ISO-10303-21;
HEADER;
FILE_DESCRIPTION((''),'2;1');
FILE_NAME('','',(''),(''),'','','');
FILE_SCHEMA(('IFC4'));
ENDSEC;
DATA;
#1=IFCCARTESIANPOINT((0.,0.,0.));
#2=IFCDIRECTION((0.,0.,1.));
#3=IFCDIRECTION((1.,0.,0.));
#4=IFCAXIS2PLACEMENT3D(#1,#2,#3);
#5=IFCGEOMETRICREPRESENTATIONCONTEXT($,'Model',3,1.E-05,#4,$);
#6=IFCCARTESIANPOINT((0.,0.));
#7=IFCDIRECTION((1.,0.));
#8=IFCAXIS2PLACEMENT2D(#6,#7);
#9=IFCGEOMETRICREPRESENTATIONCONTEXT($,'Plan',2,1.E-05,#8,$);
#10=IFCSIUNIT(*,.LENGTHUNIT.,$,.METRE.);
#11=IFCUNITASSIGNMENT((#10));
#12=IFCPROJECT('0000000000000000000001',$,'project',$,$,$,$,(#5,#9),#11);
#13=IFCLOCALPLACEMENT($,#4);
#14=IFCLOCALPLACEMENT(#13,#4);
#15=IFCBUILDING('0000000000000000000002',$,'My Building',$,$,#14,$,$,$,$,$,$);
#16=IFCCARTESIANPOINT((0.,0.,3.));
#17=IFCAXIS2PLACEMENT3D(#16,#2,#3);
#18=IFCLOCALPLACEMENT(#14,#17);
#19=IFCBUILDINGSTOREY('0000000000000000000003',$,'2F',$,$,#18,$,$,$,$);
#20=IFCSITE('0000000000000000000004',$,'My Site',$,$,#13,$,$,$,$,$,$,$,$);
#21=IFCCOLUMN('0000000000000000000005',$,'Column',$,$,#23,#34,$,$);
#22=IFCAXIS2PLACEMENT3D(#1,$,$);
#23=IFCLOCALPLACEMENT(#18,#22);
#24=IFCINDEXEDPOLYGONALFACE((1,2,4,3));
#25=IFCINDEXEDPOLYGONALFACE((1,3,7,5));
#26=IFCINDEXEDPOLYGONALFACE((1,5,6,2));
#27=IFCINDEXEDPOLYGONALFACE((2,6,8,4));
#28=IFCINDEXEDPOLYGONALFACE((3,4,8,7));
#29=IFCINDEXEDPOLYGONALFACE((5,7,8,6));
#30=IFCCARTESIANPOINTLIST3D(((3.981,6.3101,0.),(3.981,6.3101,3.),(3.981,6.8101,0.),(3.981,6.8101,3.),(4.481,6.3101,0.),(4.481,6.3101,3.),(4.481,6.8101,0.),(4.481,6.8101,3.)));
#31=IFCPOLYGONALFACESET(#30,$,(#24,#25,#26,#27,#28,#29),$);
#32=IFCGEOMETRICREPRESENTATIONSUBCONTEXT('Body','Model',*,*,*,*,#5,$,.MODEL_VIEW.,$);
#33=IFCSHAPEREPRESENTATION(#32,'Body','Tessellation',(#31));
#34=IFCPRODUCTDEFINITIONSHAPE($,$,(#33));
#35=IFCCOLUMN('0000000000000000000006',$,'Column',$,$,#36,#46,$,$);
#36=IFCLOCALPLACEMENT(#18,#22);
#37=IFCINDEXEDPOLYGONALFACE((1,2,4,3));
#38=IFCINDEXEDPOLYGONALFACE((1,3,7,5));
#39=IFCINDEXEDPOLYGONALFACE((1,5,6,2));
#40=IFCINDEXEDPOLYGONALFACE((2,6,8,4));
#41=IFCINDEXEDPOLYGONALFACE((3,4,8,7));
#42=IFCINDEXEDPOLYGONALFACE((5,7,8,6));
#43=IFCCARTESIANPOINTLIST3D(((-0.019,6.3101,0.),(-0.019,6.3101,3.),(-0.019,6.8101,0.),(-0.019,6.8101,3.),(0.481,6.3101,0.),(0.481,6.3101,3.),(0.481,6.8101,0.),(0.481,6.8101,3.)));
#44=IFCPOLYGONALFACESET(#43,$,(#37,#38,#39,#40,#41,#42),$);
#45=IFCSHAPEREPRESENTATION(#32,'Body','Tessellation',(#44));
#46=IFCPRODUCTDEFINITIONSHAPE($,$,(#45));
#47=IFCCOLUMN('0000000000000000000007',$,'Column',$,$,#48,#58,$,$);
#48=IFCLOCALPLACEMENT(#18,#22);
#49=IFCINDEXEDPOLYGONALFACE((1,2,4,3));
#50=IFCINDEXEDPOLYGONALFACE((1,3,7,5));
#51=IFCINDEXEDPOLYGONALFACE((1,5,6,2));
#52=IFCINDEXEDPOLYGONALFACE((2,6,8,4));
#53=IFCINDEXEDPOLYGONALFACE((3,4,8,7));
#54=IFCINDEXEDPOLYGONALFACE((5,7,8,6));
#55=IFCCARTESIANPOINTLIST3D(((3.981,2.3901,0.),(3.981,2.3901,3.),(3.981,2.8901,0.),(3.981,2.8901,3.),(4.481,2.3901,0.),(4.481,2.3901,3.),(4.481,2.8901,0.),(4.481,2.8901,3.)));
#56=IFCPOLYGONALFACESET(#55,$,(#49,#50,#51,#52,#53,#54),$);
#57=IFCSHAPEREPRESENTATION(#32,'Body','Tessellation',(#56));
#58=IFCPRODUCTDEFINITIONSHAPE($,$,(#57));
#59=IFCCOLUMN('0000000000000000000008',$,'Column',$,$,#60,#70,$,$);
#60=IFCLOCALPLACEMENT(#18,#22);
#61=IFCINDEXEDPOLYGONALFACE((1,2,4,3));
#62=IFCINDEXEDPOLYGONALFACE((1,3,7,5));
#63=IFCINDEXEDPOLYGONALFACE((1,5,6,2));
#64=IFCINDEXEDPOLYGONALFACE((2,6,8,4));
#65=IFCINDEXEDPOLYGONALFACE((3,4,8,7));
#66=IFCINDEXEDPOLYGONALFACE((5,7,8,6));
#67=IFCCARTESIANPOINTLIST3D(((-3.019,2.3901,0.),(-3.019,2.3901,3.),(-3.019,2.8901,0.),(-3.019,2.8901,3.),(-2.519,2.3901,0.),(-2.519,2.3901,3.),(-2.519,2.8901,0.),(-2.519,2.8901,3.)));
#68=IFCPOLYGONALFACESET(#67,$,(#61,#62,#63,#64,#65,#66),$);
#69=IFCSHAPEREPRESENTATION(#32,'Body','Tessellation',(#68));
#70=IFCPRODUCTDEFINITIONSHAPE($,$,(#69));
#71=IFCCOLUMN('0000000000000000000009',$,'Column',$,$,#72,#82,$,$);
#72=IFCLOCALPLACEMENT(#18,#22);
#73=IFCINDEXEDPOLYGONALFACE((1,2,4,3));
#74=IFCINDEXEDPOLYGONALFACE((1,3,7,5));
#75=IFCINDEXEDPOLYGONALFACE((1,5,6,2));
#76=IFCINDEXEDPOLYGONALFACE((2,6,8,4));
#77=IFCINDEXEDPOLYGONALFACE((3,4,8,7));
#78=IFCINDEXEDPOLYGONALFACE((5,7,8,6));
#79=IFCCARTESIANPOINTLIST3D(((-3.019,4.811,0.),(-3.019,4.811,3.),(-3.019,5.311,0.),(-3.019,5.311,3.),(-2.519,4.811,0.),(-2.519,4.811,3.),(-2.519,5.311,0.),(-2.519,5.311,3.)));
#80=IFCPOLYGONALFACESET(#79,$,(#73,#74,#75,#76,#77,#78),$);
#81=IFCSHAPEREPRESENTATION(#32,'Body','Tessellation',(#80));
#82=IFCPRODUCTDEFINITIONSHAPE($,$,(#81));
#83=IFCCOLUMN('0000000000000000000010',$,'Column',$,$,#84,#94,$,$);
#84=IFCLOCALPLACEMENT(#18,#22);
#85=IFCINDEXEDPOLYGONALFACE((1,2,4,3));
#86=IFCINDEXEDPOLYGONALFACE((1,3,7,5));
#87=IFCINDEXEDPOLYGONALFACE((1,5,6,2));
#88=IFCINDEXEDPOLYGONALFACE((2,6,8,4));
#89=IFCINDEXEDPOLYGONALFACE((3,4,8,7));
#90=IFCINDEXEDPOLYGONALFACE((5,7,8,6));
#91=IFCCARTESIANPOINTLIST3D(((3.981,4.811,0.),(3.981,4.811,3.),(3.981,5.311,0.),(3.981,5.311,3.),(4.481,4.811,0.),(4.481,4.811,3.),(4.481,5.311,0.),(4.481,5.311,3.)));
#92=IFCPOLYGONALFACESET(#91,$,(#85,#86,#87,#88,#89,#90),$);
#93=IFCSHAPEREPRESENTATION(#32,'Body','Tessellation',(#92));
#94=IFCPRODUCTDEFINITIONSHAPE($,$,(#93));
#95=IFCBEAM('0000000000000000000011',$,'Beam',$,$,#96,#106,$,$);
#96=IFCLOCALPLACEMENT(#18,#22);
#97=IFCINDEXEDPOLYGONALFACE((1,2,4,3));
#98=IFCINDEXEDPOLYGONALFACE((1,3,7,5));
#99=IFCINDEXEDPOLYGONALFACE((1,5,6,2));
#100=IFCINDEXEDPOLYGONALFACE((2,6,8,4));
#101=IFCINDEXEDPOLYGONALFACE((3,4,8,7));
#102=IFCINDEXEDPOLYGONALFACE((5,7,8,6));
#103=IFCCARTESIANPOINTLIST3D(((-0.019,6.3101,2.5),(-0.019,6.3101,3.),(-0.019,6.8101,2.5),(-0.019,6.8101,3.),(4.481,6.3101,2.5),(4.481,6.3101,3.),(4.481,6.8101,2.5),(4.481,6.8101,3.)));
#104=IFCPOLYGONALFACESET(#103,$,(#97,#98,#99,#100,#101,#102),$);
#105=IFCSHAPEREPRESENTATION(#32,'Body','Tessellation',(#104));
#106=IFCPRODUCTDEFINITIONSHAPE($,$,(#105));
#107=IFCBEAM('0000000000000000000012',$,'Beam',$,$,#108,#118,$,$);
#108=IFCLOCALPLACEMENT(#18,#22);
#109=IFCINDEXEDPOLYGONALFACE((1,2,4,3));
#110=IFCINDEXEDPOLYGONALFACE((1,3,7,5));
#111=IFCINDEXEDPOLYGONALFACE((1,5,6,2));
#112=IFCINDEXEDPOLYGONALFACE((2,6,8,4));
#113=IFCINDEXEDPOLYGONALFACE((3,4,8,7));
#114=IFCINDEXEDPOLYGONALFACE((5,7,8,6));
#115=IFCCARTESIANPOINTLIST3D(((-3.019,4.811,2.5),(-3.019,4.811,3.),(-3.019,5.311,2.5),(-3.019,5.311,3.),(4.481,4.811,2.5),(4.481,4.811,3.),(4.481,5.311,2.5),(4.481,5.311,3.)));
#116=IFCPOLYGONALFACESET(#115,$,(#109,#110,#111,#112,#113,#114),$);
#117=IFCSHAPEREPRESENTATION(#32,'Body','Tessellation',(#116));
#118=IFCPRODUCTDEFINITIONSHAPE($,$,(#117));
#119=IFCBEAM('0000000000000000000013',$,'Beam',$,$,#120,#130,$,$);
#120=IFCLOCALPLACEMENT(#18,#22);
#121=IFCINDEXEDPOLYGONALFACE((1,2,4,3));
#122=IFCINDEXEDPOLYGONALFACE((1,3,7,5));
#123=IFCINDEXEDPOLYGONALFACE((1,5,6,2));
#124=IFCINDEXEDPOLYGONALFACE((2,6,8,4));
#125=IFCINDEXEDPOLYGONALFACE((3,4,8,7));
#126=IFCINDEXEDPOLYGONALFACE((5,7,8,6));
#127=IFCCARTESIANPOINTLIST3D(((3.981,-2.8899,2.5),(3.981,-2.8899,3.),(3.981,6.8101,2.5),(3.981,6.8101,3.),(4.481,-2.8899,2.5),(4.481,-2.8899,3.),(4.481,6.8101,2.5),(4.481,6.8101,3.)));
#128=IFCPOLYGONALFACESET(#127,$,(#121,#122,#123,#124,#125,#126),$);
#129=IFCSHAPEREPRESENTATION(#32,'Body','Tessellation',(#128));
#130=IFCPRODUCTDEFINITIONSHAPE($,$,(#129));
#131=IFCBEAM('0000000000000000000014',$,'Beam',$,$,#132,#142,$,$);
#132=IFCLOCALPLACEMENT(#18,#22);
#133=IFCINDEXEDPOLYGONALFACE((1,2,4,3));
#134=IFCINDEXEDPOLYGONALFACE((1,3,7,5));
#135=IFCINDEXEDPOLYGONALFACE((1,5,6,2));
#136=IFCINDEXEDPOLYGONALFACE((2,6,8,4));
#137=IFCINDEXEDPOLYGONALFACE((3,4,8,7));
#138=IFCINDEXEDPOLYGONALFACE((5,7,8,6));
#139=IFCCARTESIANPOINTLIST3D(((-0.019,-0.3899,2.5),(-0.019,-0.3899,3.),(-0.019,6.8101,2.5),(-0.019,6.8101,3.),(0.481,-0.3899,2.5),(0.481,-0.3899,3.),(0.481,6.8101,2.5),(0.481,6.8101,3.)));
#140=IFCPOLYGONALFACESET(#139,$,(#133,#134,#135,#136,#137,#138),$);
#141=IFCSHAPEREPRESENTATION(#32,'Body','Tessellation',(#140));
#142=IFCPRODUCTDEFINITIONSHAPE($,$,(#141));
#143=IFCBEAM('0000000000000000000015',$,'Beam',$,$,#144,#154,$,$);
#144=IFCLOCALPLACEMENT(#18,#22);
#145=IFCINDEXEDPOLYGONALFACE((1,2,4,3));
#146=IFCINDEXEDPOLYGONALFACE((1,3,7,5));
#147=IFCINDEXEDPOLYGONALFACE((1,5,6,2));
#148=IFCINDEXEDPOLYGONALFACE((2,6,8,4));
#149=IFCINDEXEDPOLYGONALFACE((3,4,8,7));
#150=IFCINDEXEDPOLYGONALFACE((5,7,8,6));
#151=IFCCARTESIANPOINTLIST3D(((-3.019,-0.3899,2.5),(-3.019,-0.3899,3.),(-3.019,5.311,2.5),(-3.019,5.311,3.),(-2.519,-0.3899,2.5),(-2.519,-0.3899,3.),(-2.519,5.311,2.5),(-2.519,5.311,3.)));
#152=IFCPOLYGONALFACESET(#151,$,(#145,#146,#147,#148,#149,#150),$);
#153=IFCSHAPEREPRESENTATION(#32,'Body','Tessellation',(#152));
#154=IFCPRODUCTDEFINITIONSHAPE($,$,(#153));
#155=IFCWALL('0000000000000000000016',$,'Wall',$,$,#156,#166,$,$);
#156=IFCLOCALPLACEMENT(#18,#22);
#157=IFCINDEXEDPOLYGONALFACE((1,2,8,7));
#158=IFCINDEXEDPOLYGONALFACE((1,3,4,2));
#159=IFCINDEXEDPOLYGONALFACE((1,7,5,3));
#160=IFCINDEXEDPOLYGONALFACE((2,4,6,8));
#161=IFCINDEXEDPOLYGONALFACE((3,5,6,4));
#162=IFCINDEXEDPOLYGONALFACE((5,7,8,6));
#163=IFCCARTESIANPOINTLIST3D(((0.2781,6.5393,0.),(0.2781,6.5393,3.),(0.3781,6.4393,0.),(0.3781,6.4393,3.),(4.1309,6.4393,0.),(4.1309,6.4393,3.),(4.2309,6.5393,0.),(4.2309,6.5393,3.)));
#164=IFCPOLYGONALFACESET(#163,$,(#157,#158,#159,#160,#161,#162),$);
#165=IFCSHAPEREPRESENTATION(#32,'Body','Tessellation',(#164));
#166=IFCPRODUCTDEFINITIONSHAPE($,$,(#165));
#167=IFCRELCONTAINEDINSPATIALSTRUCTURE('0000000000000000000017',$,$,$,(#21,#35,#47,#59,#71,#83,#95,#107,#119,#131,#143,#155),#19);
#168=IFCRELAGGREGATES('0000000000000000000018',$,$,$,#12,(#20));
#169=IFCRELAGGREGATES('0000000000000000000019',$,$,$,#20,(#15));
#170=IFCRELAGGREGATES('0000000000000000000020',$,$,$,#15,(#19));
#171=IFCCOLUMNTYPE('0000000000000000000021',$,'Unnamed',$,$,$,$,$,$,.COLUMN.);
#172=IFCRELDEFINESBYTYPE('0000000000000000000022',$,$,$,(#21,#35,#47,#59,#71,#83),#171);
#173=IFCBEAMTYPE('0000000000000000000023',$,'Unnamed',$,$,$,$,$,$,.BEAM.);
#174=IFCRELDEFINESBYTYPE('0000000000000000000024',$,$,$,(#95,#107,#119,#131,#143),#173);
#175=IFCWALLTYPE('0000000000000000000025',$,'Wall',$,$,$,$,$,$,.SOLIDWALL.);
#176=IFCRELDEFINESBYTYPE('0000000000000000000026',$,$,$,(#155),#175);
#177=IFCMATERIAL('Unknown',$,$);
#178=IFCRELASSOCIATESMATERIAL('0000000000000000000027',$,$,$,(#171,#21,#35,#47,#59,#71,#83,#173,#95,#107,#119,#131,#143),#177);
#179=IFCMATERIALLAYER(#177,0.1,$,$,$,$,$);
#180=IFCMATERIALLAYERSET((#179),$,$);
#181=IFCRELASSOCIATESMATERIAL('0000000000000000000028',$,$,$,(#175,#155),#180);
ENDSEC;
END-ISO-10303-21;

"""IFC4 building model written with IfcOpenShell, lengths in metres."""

from ifc_helpers import new_model, si_unit, frame, origin_with_axes, origin_2d_with_axis, place, context, subcontext, project, spatial, line, indexed_curve, rectangle, outline, extrude, material, layer, layer_set, layer_usage, material_profile, profile_set, profile_usage, type_object, element, save


model = new_model("IFC4")

# Units and contexts
model_context = context("Model", 3, precision=1e-05, world=origin_with_axes())
plan_context = context("Plan", 2, precision=1e-05, world=origin_2d_with_axis())
body_context_1 = subcontext(model_context, "Body", "Model", "MODEL_VIEW")
ifc_project = project(units=[si_unit("LENGTHUNIT", "METRE")], contexts=[model_context, plan_context])

# Site, building, storey
site_placement = place(None, origin_with_axes())
site = spatial("IfcSite", under=ifc_project, at=site_placement, Name="My Site")
building_placement = place(site_placement, origin_with_axes())
building = spatial("IfcBuilding", under=site, at=building_placement, Name="My Building")
storey_placement = place(building_placement, frame((0.0, 0.0, 3.0), z_axis=(0.0, 0.0, 1.0), x_axis=(1.0, 0.0, 0.0)))
storey = spatial("IfcBuildingStorey", under=building, at=storey_placement, Name="2F")

# Columns
ifc_material = material(Name="Unknown")
ifc_material_profile_1 = material_profile(ifc_material, rectangle(XDim=0.5, YDim=0.5))
ifc_profile_set_1 = profile_set([ifc_material_profile_1])
ifc_profile_usage_1 = profile_usage(ifc_profile_set_1, cardinal=7)
column_type = type_object("IfcColumnType", Name="Unnamed", PredefinedType="COLUMN", material=ifc_profile_set_1)
column_1_placement = place(storey_placement, frame((4.481, 6.8101, 0.0), z_axis=(0.0, 0.0, 1.0), x_axis=(1.0, 0.0, 0.0)))
element("IfcColumn", 1, at=column_1_placement, inside=storey, type_object=column_type, material=ifc_profile_usage_1, Name="Column", context=body_context_1, shape_type="SweptSolid", body=[
    extrude(rectangle(XDim=0.5, YDim=0.5), frame((-0.25, -0.25, 0.0), z_axis=(0.0, 0.0, 1.0), x_axis=(1.0, 0.0, 0.0)), (0.0, 0.0, 1.0), 3.0),
])
ifc_profile_usage_2 = profile_usage(ifc_profile_set_1, cardinal=7)
column_2_placement = place(storey_placement, frame((0.481, 6.8101, 0.0), z_axis=(0.0, 0.0, 1.0), x_axis=(1.0, 0.0, 0.0)))
element("IfcColumn", 2, at=column_2_placement, inside=storey, type_object=column_type, material=ifc_profile_usage_2, Name="Column", context=body_context_1, shape_type="SweptSolid", body=[
    extrude(rectangle(XDim=0.5, YDim=0.5), frame((-0.25, -0.25, 0.0), z_axis=(0.0, 0.0, 1.0), x_axis=(1.0, 0.0, 0.0)), (0.0, 0.0, 1.0), 3.0),
])
ifc_profile_usage_3 = profile_usage(ifc_profile_set_1, cardinal=7)
column_3_placement = place(storey_placement, frame((4.481, 2.8901, 0.0), z_axis=(0.0, 0.0, 1.0), x_axis=(1.0, 0.0, 0.0)))
element("IfcColumn", 3, at=column_3_placement, inside=storey, type_object=column_type, material=ifc_profile_usage_3, Name="Column", context=body_context_1, shape_type="SweptSolid", body=[
    extrude(rectangle(XDim=0.5, YDim=0.5), frame((-0.25, -0.25, 0.0), z_axis=(0.0, 0.0, 1.0), x_axis=(1.0, 0.0, 0.0)), (0.0, 0.0, 1.0), 3.0),
])
ifc_profile_usage_4 = profile_usage(ifc_profile_set_1, cardinal=7)
column_4_placement = place(storey_placement, frame((-2.519, 2.8901, 0.0), z_axis=(0.0, 0.0, 1.0), x_axis=(1.0, 0.0, 0.0)))
element("IfcColumn", 4, at=column_4_placement, inside=storey, type_object=column_type, material=ifc_profile_usage_4, Name="Column", context=body_context_1, shape_type="SweptSolid", body=[
    extrude(rectangle(XDim=0.5, YDim=0.5), frame((-0.25, -0.25, 0.0), z_axis=(0.0, 0.0, 1.0), x_axis=(1.0, 0.0, 0.0)), (0.0, 0.0, 1.0), 3.0),
])
ifc_profile_usage_5 = profile_usage(ifc_profile_set_1, cardinal=7)
column_5_placement = place(storey_placement, frame((-2.519, 5.311, 0.0), z_axis=(0.0, 0.0, 1.0), x_axis=(1.0, 0.0, 0.0)))
element("IfcColumn", 5, at=column_5_placement, inside=storey, type_object=column_type, material=ifc_profile_usage_5, Name="Column", context=body_context_1, shape_type="SweptSolid", body=[
    extrude(rectangle(XDim=0.5, YDim=0.5), frame((-0.25, -0.25, 0.0), z_axis=(0.0, 0.0, 1.0), x_axis=(1.0, 0.0, 0.0)), (0.0, 0.0, 1.0), 3.0),
])
ifc_profile_usage_6 = profile_usage(ifc_profile_set_1, cardinal=7)
column_6_placement = place(storey_placement, frame((4.481, 5.311, 0.0), z_axis=(0.0, 0.0, 1.0), x_axis=(1.0, 0.0, 0.0)))
element("IfcColumn", 6, at=column_6_placement, inside=storey, type_object=column_type, material=ifc_profile_usage_6, Name="Column", context=body_context_1, shape_type="SweptSolid", body=[
    extrude(rectangle(XDim=0.5, YDim=0.5), frame((-0.25, -0.25, 0.0), z_axis=(0.0, 0.0, 1.0), x_axis=(1.0, 0.0, 0.0)), (0.0, 0.0, 1.0), 3.0),
])

# Beams
ifc_material_profile_2 = material_profile(ifc_material, rectangle(XDim=0.5, YDim=0.5))
ifc_profile_set_2 = profile_set([ifc_material_profile_2])
ifc_profile_usage_7 = profile_usage(ifc_profile_set_2, cardinal=7)
beam_type = type_object("IfcBeamType", Name="Unnamed", PredefinedType="BEAM", material=ifc_profile_set_2)
beam_1_placement = place(storey_placement, frame((4.481, 6.3101, 3.0), z_axis=(-1.0, 0.0, 0.0), x_axis=(0.0, -1.0, 0.0)))
element("IfcBeam", 7, at=beam_1_placement, inside=storey, type_object=beam_type, material=ifc_profile_usage_7, Name="Beam", context=body_context_1, shape_type="SweptSolid", body=[
    extrude(rectangle(XDim=0.5, YDim=0.5), frame((-0.25, -0.25, 0.0), z_axis=(0.0, 0.0, 1.0), x_axis=(1.0, 0.0, 0.0)), (0.0, 0.0, 1.0), 4.5),
])
ifc_profile_usage_8 = profile_usage(ifc_profile_set_2, cardinal=7)
beam_2_placement = place(storey_placement, frame((4.481, 4.811, 3.0), z_axis=(-1.0, 0.0, 0.0), x_axis=(0.0, -1.0, 0.0)))
element("IfcBeam", 8, at=beam_2_placement, inside=storey, type_object=beam_type, material=ifc_profile_usage_8, Name="Beam", context=body_context_1, shape_type="SweptSolid", body=[
    extrude(rectangle(XDim=0.5, YDim=0.5), frame((-0.25, -0.25, 0.0), z_axis=(0.0, 0.0, 1.0), x_axis=(1.0, 0.0, 0.0)), (0.0, 0.0, 1.0), 7.5),
])
ifc_profile_usage_9 = profile_usage(ifc_profile_set_2, cardinal=7)
beam_3_placement = place(storey_placement, frame((4.481, 6.8101, 3.0), z_axis=(0.0, -1.0, 0.0), x_axis=(1.0, 0.0, 0.0)))
element("IfcBeam", 9, at=beam_3_placement, inside=storey, type_object=beam_type, material=ifc_profile_usage_9, Name="Beam", context=body_context_1, shape_type="SweptSolid", body=[
    extrude(rectangle(XDim=0.5, YDim=0.5), frame((-0.25, -0.25, 0.0), z_axis=(0.0, 0.0, 1.0), x_axis=(1.0, 0.0, 0.0)), (0.0, 0.0, 1.0), 9.7),
])
ifc_profile_usage_10 = profile_usage(ifc_profile_set_2, cardinal=7)
beam_4_placement = place(storey_placement, frame((0.481, 6.8101, 3.0), z_axis=(0.0, -1.0, -0.000001), x_axis=(1.0, 0.0, 0.0)))
element("IfcBeam", 10, at=beam_4_placement, inside=storey, type_object=beam_type, material=ifc_profile_usage_10, Name="Beam", context=body_context_1, shape_type="SweptSolid", body=[
    extrude(rectangle(XDim=0.5, YDim=0.5), frame((-0.25, -0.25, 0.0), z_axis=(0.0, 0.0, 1.0), x_axis=(1.0, 0.0, 0.0)), (0.0, 0.0, 1.0), 7.2),
])
ifc_profile_usage_11 = profile_usage(ifc_profile_set_2, cardinal=7)
beam_5_placement = place(storey_placement, frame((-2.519, 5.311, 3.0), z_axis=(0.0, -1.0, -0.000001), x_axis=(1.0, 0.0, 0.0)))
element("IfcBeam", 11, at=beam_5_placement, inside=storey, type_object=beam_type, material=ifc_profile_usage_11, Name="Beam", context=body_context_1, shape_type="SweptSolid", body=[
    extrude(rectangle(XDim=0.5, YDim=0.5), frame((-0.25, -0.25, 0.0), z_axis=(0.0, 0.0, 1.0), x_axis=(1.0, 0.0, 0.0)), (0.0, 0.0, 1.0), 5.7009),
])

# Wall
ifc_layer = layer(ifc_material, 0.1)
ifc_layer_set = layer_set([ifc_layer])
ifc_layer_usage_1 = layer_usage(ifc_layer_set, "AXIS2", "POSITIVE", 0.0)
wall_type = type_object("IfcWallType", Name="Wall", PredefinedType="SOLIDWALL", material=ifc_layer_set)
wall_1_placement = place(storey_placement, frame((4.2309, 6.5393, 0.0), z_axis=(0.0, 0.0, 1.0), x_axis=(-1.0, 0.0, 0.0)))
element("IfcWall", 12, at=wall_1_placement, inside=storey, type_object=wall_type, material=ifc_layer_usage_1, Name="Wall", context=body_context_1, shape_type="SweptSolid", body=[
    extrude(outline(indexed_curve([(0.0, 0.0), (0.1, 0.1), (3.8528, 0.1), (3.9528, 0.0)], segments=[line(1, 2, 3, 4, 1)])), origin_with_axes(), (0.0, 0.0, 1.0), 3.0),
])

save(model, "model.ifc")
